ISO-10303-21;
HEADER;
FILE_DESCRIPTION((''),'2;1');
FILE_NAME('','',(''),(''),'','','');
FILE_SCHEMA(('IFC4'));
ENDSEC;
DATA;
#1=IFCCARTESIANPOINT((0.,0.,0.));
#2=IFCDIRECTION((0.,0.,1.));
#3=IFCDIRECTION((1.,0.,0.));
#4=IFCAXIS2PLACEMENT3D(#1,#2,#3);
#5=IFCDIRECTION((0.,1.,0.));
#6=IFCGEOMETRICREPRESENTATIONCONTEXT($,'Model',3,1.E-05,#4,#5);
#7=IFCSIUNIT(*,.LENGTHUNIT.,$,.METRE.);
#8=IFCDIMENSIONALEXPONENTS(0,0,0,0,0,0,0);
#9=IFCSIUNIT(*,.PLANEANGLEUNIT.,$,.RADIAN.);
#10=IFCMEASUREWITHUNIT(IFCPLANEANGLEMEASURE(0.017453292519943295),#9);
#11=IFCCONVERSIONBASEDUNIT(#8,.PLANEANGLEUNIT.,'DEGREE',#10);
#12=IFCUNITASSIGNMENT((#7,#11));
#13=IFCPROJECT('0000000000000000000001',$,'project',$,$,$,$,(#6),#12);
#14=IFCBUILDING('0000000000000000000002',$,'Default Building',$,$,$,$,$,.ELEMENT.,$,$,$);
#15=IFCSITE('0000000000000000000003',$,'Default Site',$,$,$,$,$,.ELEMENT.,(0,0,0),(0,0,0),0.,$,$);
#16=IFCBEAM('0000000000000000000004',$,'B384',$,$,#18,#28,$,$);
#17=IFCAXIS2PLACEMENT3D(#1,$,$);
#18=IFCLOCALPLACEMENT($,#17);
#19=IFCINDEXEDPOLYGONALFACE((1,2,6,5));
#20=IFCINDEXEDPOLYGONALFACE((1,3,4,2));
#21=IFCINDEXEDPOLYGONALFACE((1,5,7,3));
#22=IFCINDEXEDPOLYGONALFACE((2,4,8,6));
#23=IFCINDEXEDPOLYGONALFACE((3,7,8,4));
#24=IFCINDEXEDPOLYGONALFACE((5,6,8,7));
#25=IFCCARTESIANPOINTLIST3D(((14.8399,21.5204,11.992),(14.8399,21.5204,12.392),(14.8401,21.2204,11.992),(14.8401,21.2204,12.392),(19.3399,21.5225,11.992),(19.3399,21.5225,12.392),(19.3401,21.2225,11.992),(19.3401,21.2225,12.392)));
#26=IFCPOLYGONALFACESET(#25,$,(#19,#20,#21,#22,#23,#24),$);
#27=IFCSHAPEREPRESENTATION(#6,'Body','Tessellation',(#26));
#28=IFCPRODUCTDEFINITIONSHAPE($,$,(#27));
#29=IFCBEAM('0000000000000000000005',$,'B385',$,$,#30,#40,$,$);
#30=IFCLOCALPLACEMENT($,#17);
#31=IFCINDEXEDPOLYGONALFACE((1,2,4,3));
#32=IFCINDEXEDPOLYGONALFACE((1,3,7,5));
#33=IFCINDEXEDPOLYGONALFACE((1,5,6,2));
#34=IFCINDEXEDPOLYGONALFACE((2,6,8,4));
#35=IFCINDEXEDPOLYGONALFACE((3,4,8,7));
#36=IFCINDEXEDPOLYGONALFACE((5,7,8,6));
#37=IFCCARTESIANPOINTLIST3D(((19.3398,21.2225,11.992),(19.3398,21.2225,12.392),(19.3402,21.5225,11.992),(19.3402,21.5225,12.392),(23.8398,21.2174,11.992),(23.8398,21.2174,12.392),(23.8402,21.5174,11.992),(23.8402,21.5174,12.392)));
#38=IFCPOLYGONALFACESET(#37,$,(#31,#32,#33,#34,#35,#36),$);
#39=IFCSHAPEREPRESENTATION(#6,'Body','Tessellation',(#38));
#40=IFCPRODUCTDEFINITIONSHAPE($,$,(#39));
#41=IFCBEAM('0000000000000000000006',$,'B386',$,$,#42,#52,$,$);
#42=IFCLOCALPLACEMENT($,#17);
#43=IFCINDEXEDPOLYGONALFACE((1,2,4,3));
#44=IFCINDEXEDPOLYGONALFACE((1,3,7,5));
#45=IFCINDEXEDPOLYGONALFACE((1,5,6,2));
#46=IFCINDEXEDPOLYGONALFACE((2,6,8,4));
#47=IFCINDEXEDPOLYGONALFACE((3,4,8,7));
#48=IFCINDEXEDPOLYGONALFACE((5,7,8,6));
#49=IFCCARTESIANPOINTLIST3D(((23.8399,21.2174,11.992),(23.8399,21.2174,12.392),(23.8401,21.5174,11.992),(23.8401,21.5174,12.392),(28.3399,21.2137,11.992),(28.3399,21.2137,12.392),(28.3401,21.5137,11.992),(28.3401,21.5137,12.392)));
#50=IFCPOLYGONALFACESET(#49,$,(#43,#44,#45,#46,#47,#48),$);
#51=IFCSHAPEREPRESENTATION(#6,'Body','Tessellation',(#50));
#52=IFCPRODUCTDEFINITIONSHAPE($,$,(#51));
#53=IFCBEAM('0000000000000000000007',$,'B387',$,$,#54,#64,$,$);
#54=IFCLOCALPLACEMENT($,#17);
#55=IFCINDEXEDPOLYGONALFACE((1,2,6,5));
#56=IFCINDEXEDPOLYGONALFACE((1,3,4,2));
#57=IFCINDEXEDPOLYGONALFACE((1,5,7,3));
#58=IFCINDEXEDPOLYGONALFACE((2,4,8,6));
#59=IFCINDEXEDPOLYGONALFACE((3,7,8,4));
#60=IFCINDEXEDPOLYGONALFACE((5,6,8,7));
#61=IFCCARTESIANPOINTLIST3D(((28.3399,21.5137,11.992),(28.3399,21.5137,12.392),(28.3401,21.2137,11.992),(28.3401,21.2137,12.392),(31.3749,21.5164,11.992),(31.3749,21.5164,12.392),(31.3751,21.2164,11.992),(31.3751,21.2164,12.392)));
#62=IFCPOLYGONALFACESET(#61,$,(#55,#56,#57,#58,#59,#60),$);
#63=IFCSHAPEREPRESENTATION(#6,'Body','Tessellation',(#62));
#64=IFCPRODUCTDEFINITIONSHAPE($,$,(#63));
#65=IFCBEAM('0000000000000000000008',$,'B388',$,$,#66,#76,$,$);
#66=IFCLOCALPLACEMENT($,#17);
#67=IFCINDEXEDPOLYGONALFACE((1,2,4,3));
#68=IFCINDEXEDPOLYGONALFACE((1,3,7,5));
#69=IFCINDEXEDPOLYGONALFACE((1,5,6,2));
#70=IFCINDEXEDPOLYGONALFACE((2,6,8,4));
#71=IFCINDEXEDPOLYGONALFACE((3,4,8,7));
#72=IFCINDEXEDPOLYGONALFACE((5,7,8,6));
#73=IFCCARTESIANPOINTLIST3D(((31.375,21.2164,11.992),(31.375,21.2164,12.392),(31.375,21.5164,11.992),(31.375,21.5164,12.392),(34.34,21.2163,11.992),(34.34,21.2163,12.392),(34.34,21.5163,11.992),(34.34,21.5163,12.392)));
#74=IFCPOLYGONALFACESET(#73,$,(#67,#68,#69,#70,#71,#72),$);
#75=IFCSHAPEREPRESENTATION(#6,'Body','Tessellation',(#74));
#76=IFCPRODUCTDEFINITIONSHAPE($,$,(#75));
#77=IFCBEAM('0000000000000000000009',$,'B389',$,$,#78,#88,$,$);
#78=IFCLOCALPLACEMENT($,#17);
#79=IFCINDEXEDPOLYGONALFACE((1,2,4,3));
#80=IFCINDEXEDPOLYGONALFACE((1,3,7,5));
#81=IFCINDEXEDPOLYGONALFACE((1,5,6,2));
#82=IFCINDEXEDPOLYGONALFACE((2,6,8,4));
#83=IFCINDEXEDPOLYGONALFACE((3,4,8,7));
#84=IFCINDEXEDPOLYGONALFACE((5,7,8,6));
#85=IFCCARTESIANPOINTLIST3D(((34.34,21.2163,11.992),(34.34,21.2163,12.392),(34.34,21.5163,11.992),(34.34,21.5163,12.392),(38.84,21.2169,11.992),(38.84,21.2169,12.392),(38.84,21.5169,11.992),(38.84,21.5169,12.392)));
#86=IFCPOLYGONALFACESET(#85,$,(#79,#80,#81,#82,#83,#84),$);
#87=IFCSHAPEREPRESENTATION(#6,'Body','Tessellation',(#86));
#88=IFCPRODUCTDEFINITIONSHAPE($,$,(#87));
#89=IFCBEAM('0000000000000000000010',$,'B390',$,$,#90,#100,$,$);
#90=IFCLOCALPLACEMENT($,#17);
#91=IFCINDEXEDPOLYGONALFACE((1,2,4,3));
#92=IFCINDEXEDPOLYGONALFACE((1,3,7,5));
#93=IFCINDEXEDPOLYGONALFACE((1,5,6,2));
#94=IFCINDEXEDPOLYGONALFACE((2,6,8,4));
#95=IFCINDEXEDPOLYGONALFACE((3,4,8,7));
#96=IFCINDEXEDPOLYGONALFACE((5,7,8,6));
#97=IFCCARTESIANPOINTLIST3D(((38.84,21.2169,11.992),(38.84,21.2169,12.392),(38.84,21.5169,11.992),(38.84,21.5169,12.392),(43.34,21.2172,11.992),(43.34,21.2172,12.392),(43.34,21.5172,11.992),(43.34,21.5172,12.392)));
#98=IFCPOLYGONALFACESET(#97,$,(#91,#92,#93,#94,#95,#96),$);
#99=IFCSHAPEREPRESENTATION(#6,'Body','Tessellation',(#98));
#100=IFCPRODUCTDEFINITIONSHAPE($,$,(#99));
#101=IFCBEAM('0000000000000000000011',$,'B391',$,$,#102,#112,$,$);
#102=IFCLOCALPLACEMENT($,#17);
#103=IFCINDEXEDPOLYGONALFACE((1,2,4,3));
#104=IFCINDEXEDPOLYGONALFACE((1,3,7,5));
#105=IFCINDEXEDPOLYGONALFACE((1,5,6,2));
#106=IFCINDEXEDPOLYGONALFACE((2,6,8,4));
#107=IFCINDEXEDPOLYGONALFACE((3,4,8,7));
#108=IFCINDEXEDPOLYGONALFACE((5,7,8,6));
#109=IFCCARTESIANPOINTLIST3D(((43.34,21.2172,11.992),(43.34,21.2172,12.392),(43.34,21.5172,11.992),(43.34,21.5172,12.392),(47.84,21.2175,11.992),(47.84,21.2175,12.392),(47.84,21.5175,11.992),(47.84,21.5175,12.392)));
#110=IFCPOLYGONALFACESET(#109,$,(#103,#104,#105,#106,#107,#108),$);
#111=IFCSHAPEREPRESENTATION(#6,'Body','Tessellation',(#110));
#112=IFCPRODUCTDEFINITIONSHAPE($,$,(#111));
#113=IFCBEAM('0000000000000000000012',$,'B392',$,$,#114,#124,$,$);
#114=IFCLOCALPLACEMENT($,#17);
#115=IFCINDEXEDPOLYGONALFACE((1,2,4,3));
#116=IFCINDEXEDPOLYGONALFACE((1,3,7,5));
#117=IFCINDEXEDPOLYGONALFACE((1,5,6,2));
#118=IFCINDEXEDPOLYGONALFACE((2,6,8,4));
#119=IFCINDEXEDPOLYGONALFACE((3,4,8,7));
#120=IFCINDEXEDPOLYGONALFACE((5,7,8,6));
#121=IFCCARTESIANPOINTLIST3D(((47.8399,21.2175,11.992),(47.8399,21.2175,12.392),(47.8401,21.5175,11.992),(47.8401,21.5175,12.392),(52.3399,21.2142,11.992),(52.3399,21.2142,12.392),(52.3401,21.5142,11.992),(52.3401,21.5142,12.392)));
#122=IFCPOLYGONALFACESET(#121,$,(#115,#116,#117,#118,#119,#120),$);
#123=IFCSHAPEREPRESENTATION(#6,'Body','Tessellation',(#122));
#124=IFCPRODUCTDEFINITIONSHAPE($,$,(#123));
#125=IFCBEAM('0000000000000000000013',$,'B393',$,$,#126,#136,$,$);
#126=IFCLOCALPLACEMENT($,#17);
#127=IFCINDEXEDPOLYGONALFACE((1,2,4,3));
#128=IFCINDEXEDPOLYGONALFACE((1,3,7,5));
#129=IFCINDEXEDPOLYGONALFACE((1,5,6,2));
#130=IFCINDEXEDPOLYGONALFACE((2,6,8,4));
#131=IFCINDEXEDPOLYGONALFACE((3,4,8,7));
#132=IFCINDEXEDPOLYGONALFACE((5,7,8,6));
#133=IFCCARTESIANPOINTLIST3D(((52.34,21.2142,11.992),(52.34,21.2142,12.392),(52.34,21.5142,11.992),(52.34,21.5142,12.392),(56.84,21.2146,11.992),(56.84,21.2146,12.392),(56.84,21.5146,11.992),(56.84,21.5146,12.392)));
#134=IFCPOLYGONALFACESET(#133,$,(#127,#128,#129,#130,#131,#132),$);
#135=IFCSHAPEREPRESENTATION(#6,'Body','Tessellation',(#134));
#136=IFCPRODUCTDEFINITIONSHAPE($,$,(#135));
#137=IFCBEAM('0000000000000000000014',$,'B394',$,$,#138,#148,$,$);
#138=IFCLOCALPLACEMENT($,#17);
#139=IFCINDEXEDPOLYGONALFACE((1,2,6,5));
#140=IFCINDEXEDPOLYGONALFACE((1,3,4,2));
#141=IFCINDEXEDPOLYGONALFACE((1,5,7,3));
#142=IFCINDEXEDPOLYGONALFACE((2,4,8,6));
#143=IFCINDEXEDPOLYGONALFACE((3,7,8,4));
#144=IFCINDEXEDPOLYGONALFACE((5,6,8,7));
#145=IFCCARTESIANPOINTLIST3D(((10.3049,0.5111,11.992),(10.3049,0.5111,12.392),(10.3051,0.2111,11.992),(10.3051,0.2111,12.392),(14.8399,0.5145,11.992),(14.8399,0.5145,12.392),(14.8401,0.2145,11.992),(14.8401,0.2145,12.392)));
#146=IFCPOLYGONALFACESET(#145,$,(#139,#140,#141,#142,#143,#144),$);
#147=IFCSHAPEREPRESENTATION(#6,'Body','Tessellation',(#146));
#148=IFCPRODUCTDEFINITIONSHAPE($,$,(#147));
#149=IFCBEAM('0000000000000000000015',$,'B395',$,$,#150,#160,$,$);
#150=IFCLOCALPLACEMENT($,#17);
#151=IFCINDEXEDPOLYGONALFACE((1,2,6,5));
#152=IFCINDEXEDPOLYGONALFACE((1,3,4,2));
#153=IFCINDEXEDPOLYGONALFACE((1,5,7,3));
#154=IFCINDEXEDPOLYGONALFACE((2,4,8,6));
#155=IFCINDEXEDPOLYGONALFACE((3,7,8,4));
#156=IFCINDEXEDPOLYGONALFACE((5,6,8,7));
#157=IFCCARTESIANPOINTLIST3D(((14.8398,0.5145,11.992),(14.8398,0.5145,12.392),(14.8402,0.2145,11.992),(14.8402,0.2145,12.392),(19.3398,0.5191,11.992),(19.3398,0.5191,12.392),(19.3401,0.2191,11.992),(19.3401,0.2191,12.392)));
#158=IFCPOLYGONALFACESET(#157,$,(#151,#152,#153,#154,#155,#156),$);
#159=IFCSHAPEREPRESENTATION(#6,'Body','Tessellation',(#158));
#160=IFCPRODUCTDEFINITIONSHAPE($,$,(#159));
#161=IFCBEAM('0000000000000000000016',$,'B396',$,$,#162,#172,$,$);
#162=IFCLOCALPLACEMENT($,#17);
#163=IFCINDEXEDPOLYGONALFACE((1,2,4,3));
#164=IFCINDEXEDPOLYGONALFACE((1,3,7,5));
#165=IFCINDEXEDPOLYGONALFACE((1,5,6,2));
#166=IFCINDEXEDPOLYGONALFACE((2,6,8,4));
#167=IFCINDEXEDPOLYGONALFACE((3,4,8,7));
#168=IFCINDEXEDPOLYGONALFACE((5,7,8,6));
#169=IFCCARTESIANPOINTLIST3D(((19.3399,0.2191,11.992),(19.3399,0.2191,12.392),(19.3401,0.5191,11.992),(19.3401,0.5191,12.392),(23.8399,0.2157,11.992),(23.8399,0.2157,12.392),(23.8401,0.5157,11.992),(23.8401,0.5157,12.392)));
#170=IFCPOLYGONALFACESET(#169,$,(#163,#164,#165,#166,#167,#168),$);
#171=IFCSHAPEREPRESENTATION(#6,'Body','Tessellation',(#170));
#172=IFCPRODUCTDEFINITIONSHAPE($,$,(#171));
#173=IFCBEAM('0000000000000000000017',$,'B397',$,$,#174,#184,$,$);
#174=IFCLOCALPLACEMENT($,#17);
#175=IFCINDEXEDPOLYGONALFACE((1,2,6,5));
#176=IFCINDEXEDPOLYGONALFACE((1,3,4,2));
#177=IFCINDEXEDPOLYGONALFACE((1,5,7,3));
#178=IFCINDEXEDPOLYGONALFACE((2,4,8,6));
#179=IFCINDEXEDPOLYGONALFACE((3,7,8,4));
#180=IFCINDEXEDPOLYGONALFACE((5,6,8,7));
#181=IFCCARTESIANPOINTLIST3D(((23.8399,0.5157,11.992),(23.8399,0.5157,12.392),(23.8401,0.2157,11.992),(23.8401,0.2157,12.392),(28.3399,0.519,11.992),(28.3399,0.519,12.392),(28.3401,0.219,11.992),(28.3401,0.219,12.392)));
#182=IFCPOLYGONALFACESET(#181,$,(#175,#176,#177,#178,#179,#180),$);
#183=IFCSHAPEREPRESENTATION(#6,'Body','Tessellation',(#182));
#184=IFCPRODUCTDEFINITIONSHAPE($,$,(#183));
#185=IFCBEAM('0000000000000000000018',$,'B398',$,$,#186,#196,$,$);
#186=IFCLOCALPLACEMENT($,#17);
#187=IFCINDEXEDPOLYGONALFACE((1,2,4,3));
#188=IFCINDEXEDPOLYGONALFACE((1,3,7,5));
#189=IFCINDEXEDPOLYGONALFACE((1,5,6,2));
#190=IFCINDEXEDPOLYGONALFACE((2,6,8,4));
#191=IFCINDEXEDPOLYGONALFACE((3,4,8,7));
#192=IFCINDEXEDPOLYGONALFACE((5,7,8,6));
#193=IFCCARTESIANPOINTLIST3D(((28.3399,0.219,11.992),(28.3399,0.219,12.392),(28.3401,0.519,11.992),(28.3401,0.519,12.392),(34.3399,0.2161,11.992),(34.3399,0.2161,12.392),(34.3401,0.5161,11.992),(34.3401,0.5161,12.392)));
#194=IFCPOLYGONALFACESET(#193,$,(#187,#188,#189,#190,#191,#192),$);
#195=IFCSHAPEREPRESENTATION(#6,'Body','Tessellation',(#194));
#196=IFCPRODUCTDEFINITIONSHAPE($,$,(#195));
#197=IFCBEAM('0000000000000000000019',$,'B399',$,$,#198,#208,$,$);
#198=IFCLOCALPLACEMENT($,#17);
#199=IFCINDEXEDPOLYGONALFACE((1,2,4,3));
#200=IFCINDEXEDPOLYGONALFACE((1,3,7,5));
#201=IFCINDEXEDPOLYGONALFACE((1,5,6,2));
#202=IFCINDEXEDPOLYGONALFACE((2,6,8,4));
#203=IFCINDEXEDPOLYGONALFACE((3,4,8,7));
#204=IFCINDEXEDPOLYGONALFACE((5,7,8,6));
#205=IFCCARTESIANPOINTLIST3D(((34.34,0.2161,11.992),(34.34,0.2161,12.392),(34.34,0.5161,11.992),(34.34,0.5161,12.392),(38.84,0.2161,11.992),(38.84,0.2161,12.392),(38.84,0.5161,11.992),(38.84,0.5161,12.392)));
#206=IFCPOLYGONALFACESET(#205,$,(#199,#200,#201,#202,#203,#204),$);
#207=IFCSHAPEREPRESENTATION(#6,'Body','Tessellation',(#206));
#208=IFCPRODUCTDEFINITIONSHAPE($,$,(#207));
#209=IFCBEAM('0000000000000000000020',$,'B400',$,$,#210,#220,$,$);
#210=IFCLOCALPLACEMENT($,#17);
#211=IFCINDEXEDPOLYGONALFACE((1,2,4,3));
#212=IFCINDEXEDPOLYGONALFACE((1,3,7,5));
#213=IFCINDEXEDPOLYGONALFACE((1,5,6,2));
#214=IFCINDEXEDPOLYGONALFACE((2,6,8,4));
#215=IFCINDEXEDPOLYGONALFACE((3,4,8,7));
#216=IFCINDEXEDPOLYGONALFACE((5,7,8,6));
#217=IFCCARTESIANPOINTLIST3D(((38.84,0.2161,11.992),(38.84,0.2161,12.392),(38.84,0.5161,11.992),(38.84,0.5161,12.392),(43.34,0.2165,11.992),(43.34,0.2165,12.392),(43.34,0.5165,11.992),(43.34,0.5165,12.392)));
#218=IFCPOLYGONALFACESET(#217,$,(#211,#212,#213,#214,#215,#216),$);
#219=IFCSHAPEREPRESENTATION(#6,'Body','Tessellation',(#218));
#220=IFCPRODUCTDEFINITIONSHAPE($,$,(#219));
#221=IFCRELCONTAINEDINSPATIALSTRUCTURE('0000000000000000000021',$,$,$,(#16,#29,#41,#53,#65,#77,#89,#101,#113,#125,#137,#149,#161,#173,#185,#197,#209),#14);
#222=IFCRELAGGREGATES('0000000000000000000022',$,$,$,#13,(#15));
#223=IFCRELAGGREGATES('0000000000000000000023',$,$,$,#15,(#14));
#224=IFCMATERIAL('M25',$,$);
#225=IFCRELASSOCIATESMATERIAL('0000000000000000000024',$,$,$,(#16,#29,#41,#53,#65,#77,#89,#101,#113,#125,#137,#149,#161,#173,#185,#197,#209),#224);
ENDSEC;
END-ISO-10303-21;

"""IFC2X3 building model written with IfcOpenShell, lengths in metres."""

from ifc_helpers import new_model, entity, si_unit, converted_unit, direction, frame, frame_2d, origin_with_axes, place, context, project, spatial, rectangle, extrude, material, element, save


model = new_model("IFC2X3")

# Units and contexts
model_context = context("Model", 3, precision=1e-05, world=origin_with_axes(), true_north=direction((0.0, 1.0, 0.0)))
ifc_project = project(units=[si_unit("LENGTHUNIT", "METRE"), converted_unit("PLANEANGLEUNIT", "DEGREE", entity("IfcPlaneAngleMeasure", 0.017453292519943295), si_unit("PLANEANGLEUNIT", "RADIAN"), dimensions=[0, 0, 0, 0, 0, 0, 0])], contexts=[model_context])

# Site, building
site = spatial("IfcSite", under=ifc_project, Name="Default Site", CompositionType="ELEMENT", RefLatitude=(0, 0, 0), RefLongitude=(0, 0, 0), RefElevation=0.0)
building = spatial("IfcBuilding", under=site, Name="Default Building", CompositionType="ELEMENT")

# Beams
ifc_material = material(Name="M25")
placement = place(None, origin_with_axes())
element("IfcBeam", 1, at=placement, inside=building, material=ifc_material, Name="B384", context=model_context, shape_type="SweptSolid", body=[
    extrude(rectangle(XDim=0.3, YDim=0.4, at=frame_2d((0.0, 0.0), x_axis=(0.0, 1.0, 0.0))), frame((14.84, 21.3704, 12.192), z_axis=(1.0, 0.000471, 0.0), x_axis=(0.0, 0.0, -1.0)), (0.0, 0.0, 1.0), 4.5),
])
element("IfcBeam", 2, at=placement, inside=building, material=ifc_material, Name="B385", context=model_context, shape_type="SweptSolid", body=[
    extrude(rectangle(XDim=0.3, YDim=0.4, at=frame_2d((0.0, 0.0), x_axis=(0.0, 1.0, 0.0))), frame((19.34, 21.3725, 12.192), z_axis=(0.999999, -0.001141, 0.0), x_axis=(0.0, 0.0, -1.0)), (0.0, 0.0, 1.0), 4.5),
])
element("IfcBeam", 3, at=placement, inside=building, material=ifc_material, Name="B386", context=model_context, shape_type="SweptSolid", body=[
    extrude(rectangle(XDim=0.3, YDim=0.4, at=frame_2d((0.0, 0.0), x_axis=(0.0, 1.0, 0.0))), frame((23.84, 21.3674, 12.192), z_axis=(1.0, -0.000812, 0.0), x_axis=(0.0, 0.0, -1.0)), (0.0, 0.0, 1.0), 4.5),
])
element("IfcBeam", 4, at=placement, inside=building, material=ifc_material, Name="B387", context=model_context, shape_type="SweptSolid", body=[
    extrude(rectangle(XDim=0.3, YDim=0.4, at=frame_2d((0.0, 0.0), x_axis=(0.0, 1.0, 0.0))), frame((28.34, 21.3637, 12.192), z_axis=(1.0, 0.000883, 0.0), x_axis=(0.0, 0.0, -1.0)), (0.0, 0.0, 1.0), 3.035),
])
element("IfcBeam", 5, at=placement, inside=building, material=ifc_material, Name="B388", context=model_context, shape_type="SweptSolid", body=[
    extrude(rectangle(XDim=0.3, YDim=0.4, at=frame_2d((0.0, 0.0), x_axis=(0.0, 1.0, 0.0))), frame((31.375, 21.3664, 12.192), z_axis=(1.0, -0.000016, 0.0), x_axis=(0.0, 0.0, -1.0)), (0.0, 0.0, 1.0), 2.965),
])
element("IfcBeam", 6, at=placement, inside=building, material=ifc_material, Name="B389", context=model_context, shape_type="SweptSolid", body=[
    extrude(rectangle(XDim=0.3, YDim=0.4, at=frame_2d((0.0, 0.0), x_axis=(0.0, 1.0, 0.0))), frame((34.34, 21.3663, 12.192), z_axis=(1.0, 0.000136, 0.0), x_axis=(0.0, 0.0, -1.0)), (0.0, 0.0, 1.0), 4.5),
])
element("IfcBeam", 7, at=placement, inside=building, material=ifc_material, Name="B390", context=model_context, shape_type="SweptSolid", body=[
    extrude(rectangle(XDim=0.3, YDim=0.4, at=frame_2d((0.0, 0.0), x_axis=(0.0, 1.0, 0.0))), frame((38.84, 21.3669, 12.192), z_axis=(1.0, 0.00005, 0.0), x_axis=(0.0, 0.0, -1.0)), (0.0, 0.0, 1.0), 4.5),
])
element("IfcBeam", 8, at=placement, inside=building, material=ifc_material, Name="B391", context=model_context, shape_type="SweptSolid", body=[
    extrude(rectangle(XDim=0.3, YDim=0.4, at=frame_2d((0.0, 0.0), x_axis=(0.0, 1.0, 0.0))), frame((43.34, 21.3672, 12.192), z_axis=(1.0, 0.000075, 0.0), x_axis=(0.0, 0.0, -1.0)), (0.0, 0.0, 1.0), 4.5),
])
element("IfcBeam", 9, at=placement, inside=building, material=ifc_material, Name="B392", context=model_context, shape_type="SweptSolid", body=[
    extrude(rectangle(XDim=0.3, YDim=0.4, at=frame_2d((0.0, 0.0), x_axis=(0.0, 1.0, 0.0))), frame((47.84, 21.3675, 12.192), z_axis=(1.0, -0.000744, 0.0), x_axis=(0.0, 0.0, -1.0)), (0.0, 0.0, 1.0), 4.5),
])
element("IfcBeam", 10, at=placement, inside=building, material=ifc_material, Name="B393", context=model_context, shape_type="SweptSolid", body=[
    extrude(rectangle(XDim=0.3, YDim=0.4, at=frame_2d((0.0, 0.0), x_axis=(0.0, 1.0, 0.0))), frame((52.34, 21.3642, 12.192), z_axis=(1.0, 0.000102, 0.0), x_axis=(0.0, 0.0, -1.0)), (0.0, 0.0, 1.0), 4.5),
])
element("IfcBeam", 11, at=placement, inside=building, material=ifc_material, Name="B394", context=model_context, shape_type="SweptSolid", body=[
    extrude(rectangle(XDim=0.3, YDim=0.4, at=frame_2d((0.0, 0.0), x_axis=(0.0, 1.0, 0.0))), frame((10.305, 0.3611, 12.192), z_axis=(1.0, 0.000762, 0.0), x_axis=(0.0, 0.0, -1.0)), (0.0, 0.0, 1.0), 4.535),
])
element("IfcBeam", 12, at=placement, inside=building, material=ifc_material, Name="B395", context=model_context, shape_type="SweptSolid", body=[
    extrude(rectangle(XDim=0.3, YDim=0.4, at=frame_2d((0.0, 0.0), x_axis=(0.0, 1.0, 0.0))), frame((14.84, 0.3645, 12.192), z_axis=(0.999999, 0.00101, 0.0), x_axis=(0.0, 0.0, -1.0)), (0.0, 0.0, 1.0), 4.5),
])
element("IfcBeam", 13, at=placement, inside=building, material=ifc_material, Name="B396", context=model_context, shape_type="SweptSolid", body=[
    extrude(rectangle(XDim=0.3, YDim=0.4, at=frame_2d((0.0, 0.0), x_axis=(0.0, 1.0, 0.0))), frame((19.34, 0.3691, 12.192), z_axis=(1.0, -0.000757, 0.0), x_axis=(0.0, 0.0, -1.0)), (0.0, 0.0, 1.0), 4.5),
])
element("IfcBeam", 14, at=placement, inside=building, material=ifc_material, Name="B397", context=model_context, shape_type="SweptSolid", body=[
    extrude(rectangle(XDim=0.3, YDim=0.4, at=frame_2d((0.0, 0.0), x_axis=(0.0, 1.0, 0.0))), frame((23.84, 0.3657, 12.192), z_axis=(1.0, 0.00075, 0.0), x_axis=(0.0, 0.0, -1.0)), (0.0, 0.0, 1.0), 4.5),
])
element("IfcBeam", 15, at=placement, inside=building, material=ifc_material, Name="B398", context=model_context, shape_type="SweptSolid", body=[
    extrude(rectangle(XDim=0.3, YDim=0.4, at=frame_2d((0.0, 0.0), x_axis=(0.0, 1.0, 0.0))), frame((28.34, 0.369, 12.192), z_axis=(1.0, -0.000487, 0.0), x_axis=(0.0, 0.0, -1.0)), (0.0, 0.0, 1.0), 6.0),
])
element("IfcBeam", 16, at=placement, inside=building, material=ifc_material, Name="B399", context=model_context, shape_type="SweptSolid", body=[
    extrude(rectangle(XDim=0.3, YDim=0.4, at=frame_2d((0.0, 0.0), x_axis=(0.0, 1.0, 0.0))), frame((34.34, 0.3661, 12.192), z_axis=(1.0, 0.000003, 0.0), x_axis=(0.0, 0.0, -1.0)), (0.0, 0.0, 1.0), 4.5),
])
element("IfcBeam", 17, at=placement, inside=building, material=ifc_material, Name="B400", context=model_context, shape_type="SweptSolid", body=[
    extrude(rectangle(XDim=0.3, YDim=0.4, at=frame_2d((0.0, 0.0), x_axis=(0.0, 1.0, 0.0))), frame((38.84, 0.3661, 12.192), z_axis=(1.0, 0.000077, 0.0), x_axis=(0.0, 0.0, -1.0)), (0.0, 0.0, 1.0), 4.5),
])

save(model, "model.ifc")
